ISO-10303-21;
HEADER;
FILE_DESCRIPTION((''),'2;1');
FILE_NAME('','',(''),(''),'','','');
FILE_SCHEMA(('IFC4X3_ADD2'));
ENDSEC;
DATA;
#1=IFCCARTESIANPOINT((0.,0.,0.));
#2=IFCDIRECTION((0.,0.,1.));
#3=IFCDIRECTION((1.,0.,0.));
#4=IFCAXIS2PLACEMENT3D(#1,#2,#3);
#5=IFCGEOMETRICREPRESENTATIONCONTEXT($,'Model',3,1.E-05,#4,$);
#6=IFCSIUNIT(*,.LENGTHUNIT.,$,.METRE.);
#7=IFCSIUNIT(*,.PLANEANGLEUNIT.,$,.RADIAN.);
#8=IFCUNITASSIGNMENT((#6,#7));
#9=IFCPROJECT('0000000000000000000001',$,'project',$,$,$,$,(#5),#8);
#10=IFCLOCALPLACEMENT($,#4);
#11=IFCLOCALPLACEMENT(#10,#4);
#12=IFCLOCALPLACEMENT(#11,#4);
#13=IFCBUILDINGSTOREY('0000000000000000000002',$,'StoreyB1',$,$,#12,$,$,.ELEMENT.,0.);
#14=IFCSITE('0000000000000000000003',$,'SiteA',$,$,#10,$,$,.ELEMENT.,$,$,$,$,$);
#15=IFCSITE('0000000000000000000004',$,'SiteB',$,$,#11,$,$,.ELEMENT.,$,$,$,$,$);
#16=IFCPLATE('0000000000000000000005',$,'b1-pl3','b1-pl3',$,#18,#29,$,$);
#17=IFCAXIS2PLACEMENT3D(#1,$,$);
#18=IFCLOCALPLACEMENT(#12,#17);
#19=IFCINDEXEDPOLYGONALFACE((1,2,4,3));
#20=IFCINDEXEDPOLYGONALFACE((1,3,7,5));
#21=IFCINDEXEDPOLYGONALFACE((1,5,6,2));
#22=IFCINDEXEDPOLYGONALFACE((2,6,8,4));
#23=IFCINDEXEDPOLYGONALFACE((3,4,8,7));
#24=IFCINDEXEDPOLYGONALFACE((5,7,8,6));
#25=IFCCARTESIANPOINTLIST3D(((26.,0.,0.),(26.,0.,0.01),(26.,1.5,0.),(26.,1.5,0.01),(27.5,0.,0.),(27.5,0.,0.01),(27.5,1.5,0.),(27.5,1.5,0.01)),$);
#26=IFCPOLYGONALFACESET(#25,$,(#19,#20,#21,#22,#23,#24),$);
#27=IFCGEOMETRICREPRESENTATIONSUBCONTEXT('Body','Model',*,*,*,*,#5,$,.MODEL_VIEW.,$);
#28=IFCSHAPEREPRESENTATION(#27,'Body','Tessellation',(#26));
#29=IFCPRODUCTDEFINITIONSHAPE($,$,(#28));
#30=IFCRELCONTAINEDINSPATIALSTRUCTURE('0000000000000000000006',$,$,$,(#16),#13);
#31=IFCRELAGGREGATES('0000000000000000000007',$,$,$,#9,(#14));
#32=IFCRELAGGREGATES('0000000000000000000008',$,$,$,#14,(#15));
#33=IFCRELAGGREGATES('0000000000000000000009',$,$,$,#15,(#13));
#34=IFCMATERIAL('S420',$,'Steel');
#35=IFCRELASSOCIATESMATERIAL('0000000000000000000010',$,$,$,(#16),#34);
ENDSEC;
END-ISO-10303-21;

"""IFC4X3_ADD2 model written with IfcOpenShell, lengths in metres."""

from ifc_helpers import new_model, si_unit, origin_with_axes, place, context, subcontext, project, spatial, line, indexed_curve, outline, extrude, material, element, save


model = new_model("IFC4X3_ADD2")

# Units and contexts
model_context = context("Model", 3, precision=1e-05, world=origin_with_axes())
body_context = subcontext(model_context, "Body", "Model", "MODEL_VIEW")
ifc_project = project(units=[si_unit("LENGTHUNIT", "METRE"), si_unit("PLANEANGLEUNIT", "RADIAN")], contexts=[model_context])

# Sites, storey
site_1_placement = place(None, origin_with_axes())
site_1 = spatial("IfcSite", under=ifc_project, at=site_1_placement, Name="SiteA", CompositionType="ELEMENT")
site_2_placement = place(site_1_placement, origin_with_axes())
site_2 = spatial("IfcSite", under=site_1, at=site_2_placement, Name="SiteB", CompositionType="ELEMENT")
storey_placement = place(site_2_placement, origin_with_axes())
storey = spatial("IfcBuildingStorey", under=site_2, at=storey_placement, Name="StoreyB1", CompositionType="ELEMENT", Elevation=0.0)

# Plate
ifc_material_1 = material(Name="S420", Category="Steel")
plate_1_placement = place(None, origin_with_axes())
element("IfcPlate", 1, at=plate_1_placement, inside=storey, material=ifc_material_1, Name="b1-pl3", Description="b1-pl3", context=body_context, shape_type="SolidModel", body=[
    extrude(outline(indexed_curve([(26.0, 0.0), (26.0, 1.5), (27.5, 0.0), (27.5, 1.5)], segments=[line(3, 1), line(1, 2), line(2, 4), line(4, 3)])), origin_with_axes(), (0.0, 0.0, 1.0), 0.01),
])

save(model, "model.ifc")
